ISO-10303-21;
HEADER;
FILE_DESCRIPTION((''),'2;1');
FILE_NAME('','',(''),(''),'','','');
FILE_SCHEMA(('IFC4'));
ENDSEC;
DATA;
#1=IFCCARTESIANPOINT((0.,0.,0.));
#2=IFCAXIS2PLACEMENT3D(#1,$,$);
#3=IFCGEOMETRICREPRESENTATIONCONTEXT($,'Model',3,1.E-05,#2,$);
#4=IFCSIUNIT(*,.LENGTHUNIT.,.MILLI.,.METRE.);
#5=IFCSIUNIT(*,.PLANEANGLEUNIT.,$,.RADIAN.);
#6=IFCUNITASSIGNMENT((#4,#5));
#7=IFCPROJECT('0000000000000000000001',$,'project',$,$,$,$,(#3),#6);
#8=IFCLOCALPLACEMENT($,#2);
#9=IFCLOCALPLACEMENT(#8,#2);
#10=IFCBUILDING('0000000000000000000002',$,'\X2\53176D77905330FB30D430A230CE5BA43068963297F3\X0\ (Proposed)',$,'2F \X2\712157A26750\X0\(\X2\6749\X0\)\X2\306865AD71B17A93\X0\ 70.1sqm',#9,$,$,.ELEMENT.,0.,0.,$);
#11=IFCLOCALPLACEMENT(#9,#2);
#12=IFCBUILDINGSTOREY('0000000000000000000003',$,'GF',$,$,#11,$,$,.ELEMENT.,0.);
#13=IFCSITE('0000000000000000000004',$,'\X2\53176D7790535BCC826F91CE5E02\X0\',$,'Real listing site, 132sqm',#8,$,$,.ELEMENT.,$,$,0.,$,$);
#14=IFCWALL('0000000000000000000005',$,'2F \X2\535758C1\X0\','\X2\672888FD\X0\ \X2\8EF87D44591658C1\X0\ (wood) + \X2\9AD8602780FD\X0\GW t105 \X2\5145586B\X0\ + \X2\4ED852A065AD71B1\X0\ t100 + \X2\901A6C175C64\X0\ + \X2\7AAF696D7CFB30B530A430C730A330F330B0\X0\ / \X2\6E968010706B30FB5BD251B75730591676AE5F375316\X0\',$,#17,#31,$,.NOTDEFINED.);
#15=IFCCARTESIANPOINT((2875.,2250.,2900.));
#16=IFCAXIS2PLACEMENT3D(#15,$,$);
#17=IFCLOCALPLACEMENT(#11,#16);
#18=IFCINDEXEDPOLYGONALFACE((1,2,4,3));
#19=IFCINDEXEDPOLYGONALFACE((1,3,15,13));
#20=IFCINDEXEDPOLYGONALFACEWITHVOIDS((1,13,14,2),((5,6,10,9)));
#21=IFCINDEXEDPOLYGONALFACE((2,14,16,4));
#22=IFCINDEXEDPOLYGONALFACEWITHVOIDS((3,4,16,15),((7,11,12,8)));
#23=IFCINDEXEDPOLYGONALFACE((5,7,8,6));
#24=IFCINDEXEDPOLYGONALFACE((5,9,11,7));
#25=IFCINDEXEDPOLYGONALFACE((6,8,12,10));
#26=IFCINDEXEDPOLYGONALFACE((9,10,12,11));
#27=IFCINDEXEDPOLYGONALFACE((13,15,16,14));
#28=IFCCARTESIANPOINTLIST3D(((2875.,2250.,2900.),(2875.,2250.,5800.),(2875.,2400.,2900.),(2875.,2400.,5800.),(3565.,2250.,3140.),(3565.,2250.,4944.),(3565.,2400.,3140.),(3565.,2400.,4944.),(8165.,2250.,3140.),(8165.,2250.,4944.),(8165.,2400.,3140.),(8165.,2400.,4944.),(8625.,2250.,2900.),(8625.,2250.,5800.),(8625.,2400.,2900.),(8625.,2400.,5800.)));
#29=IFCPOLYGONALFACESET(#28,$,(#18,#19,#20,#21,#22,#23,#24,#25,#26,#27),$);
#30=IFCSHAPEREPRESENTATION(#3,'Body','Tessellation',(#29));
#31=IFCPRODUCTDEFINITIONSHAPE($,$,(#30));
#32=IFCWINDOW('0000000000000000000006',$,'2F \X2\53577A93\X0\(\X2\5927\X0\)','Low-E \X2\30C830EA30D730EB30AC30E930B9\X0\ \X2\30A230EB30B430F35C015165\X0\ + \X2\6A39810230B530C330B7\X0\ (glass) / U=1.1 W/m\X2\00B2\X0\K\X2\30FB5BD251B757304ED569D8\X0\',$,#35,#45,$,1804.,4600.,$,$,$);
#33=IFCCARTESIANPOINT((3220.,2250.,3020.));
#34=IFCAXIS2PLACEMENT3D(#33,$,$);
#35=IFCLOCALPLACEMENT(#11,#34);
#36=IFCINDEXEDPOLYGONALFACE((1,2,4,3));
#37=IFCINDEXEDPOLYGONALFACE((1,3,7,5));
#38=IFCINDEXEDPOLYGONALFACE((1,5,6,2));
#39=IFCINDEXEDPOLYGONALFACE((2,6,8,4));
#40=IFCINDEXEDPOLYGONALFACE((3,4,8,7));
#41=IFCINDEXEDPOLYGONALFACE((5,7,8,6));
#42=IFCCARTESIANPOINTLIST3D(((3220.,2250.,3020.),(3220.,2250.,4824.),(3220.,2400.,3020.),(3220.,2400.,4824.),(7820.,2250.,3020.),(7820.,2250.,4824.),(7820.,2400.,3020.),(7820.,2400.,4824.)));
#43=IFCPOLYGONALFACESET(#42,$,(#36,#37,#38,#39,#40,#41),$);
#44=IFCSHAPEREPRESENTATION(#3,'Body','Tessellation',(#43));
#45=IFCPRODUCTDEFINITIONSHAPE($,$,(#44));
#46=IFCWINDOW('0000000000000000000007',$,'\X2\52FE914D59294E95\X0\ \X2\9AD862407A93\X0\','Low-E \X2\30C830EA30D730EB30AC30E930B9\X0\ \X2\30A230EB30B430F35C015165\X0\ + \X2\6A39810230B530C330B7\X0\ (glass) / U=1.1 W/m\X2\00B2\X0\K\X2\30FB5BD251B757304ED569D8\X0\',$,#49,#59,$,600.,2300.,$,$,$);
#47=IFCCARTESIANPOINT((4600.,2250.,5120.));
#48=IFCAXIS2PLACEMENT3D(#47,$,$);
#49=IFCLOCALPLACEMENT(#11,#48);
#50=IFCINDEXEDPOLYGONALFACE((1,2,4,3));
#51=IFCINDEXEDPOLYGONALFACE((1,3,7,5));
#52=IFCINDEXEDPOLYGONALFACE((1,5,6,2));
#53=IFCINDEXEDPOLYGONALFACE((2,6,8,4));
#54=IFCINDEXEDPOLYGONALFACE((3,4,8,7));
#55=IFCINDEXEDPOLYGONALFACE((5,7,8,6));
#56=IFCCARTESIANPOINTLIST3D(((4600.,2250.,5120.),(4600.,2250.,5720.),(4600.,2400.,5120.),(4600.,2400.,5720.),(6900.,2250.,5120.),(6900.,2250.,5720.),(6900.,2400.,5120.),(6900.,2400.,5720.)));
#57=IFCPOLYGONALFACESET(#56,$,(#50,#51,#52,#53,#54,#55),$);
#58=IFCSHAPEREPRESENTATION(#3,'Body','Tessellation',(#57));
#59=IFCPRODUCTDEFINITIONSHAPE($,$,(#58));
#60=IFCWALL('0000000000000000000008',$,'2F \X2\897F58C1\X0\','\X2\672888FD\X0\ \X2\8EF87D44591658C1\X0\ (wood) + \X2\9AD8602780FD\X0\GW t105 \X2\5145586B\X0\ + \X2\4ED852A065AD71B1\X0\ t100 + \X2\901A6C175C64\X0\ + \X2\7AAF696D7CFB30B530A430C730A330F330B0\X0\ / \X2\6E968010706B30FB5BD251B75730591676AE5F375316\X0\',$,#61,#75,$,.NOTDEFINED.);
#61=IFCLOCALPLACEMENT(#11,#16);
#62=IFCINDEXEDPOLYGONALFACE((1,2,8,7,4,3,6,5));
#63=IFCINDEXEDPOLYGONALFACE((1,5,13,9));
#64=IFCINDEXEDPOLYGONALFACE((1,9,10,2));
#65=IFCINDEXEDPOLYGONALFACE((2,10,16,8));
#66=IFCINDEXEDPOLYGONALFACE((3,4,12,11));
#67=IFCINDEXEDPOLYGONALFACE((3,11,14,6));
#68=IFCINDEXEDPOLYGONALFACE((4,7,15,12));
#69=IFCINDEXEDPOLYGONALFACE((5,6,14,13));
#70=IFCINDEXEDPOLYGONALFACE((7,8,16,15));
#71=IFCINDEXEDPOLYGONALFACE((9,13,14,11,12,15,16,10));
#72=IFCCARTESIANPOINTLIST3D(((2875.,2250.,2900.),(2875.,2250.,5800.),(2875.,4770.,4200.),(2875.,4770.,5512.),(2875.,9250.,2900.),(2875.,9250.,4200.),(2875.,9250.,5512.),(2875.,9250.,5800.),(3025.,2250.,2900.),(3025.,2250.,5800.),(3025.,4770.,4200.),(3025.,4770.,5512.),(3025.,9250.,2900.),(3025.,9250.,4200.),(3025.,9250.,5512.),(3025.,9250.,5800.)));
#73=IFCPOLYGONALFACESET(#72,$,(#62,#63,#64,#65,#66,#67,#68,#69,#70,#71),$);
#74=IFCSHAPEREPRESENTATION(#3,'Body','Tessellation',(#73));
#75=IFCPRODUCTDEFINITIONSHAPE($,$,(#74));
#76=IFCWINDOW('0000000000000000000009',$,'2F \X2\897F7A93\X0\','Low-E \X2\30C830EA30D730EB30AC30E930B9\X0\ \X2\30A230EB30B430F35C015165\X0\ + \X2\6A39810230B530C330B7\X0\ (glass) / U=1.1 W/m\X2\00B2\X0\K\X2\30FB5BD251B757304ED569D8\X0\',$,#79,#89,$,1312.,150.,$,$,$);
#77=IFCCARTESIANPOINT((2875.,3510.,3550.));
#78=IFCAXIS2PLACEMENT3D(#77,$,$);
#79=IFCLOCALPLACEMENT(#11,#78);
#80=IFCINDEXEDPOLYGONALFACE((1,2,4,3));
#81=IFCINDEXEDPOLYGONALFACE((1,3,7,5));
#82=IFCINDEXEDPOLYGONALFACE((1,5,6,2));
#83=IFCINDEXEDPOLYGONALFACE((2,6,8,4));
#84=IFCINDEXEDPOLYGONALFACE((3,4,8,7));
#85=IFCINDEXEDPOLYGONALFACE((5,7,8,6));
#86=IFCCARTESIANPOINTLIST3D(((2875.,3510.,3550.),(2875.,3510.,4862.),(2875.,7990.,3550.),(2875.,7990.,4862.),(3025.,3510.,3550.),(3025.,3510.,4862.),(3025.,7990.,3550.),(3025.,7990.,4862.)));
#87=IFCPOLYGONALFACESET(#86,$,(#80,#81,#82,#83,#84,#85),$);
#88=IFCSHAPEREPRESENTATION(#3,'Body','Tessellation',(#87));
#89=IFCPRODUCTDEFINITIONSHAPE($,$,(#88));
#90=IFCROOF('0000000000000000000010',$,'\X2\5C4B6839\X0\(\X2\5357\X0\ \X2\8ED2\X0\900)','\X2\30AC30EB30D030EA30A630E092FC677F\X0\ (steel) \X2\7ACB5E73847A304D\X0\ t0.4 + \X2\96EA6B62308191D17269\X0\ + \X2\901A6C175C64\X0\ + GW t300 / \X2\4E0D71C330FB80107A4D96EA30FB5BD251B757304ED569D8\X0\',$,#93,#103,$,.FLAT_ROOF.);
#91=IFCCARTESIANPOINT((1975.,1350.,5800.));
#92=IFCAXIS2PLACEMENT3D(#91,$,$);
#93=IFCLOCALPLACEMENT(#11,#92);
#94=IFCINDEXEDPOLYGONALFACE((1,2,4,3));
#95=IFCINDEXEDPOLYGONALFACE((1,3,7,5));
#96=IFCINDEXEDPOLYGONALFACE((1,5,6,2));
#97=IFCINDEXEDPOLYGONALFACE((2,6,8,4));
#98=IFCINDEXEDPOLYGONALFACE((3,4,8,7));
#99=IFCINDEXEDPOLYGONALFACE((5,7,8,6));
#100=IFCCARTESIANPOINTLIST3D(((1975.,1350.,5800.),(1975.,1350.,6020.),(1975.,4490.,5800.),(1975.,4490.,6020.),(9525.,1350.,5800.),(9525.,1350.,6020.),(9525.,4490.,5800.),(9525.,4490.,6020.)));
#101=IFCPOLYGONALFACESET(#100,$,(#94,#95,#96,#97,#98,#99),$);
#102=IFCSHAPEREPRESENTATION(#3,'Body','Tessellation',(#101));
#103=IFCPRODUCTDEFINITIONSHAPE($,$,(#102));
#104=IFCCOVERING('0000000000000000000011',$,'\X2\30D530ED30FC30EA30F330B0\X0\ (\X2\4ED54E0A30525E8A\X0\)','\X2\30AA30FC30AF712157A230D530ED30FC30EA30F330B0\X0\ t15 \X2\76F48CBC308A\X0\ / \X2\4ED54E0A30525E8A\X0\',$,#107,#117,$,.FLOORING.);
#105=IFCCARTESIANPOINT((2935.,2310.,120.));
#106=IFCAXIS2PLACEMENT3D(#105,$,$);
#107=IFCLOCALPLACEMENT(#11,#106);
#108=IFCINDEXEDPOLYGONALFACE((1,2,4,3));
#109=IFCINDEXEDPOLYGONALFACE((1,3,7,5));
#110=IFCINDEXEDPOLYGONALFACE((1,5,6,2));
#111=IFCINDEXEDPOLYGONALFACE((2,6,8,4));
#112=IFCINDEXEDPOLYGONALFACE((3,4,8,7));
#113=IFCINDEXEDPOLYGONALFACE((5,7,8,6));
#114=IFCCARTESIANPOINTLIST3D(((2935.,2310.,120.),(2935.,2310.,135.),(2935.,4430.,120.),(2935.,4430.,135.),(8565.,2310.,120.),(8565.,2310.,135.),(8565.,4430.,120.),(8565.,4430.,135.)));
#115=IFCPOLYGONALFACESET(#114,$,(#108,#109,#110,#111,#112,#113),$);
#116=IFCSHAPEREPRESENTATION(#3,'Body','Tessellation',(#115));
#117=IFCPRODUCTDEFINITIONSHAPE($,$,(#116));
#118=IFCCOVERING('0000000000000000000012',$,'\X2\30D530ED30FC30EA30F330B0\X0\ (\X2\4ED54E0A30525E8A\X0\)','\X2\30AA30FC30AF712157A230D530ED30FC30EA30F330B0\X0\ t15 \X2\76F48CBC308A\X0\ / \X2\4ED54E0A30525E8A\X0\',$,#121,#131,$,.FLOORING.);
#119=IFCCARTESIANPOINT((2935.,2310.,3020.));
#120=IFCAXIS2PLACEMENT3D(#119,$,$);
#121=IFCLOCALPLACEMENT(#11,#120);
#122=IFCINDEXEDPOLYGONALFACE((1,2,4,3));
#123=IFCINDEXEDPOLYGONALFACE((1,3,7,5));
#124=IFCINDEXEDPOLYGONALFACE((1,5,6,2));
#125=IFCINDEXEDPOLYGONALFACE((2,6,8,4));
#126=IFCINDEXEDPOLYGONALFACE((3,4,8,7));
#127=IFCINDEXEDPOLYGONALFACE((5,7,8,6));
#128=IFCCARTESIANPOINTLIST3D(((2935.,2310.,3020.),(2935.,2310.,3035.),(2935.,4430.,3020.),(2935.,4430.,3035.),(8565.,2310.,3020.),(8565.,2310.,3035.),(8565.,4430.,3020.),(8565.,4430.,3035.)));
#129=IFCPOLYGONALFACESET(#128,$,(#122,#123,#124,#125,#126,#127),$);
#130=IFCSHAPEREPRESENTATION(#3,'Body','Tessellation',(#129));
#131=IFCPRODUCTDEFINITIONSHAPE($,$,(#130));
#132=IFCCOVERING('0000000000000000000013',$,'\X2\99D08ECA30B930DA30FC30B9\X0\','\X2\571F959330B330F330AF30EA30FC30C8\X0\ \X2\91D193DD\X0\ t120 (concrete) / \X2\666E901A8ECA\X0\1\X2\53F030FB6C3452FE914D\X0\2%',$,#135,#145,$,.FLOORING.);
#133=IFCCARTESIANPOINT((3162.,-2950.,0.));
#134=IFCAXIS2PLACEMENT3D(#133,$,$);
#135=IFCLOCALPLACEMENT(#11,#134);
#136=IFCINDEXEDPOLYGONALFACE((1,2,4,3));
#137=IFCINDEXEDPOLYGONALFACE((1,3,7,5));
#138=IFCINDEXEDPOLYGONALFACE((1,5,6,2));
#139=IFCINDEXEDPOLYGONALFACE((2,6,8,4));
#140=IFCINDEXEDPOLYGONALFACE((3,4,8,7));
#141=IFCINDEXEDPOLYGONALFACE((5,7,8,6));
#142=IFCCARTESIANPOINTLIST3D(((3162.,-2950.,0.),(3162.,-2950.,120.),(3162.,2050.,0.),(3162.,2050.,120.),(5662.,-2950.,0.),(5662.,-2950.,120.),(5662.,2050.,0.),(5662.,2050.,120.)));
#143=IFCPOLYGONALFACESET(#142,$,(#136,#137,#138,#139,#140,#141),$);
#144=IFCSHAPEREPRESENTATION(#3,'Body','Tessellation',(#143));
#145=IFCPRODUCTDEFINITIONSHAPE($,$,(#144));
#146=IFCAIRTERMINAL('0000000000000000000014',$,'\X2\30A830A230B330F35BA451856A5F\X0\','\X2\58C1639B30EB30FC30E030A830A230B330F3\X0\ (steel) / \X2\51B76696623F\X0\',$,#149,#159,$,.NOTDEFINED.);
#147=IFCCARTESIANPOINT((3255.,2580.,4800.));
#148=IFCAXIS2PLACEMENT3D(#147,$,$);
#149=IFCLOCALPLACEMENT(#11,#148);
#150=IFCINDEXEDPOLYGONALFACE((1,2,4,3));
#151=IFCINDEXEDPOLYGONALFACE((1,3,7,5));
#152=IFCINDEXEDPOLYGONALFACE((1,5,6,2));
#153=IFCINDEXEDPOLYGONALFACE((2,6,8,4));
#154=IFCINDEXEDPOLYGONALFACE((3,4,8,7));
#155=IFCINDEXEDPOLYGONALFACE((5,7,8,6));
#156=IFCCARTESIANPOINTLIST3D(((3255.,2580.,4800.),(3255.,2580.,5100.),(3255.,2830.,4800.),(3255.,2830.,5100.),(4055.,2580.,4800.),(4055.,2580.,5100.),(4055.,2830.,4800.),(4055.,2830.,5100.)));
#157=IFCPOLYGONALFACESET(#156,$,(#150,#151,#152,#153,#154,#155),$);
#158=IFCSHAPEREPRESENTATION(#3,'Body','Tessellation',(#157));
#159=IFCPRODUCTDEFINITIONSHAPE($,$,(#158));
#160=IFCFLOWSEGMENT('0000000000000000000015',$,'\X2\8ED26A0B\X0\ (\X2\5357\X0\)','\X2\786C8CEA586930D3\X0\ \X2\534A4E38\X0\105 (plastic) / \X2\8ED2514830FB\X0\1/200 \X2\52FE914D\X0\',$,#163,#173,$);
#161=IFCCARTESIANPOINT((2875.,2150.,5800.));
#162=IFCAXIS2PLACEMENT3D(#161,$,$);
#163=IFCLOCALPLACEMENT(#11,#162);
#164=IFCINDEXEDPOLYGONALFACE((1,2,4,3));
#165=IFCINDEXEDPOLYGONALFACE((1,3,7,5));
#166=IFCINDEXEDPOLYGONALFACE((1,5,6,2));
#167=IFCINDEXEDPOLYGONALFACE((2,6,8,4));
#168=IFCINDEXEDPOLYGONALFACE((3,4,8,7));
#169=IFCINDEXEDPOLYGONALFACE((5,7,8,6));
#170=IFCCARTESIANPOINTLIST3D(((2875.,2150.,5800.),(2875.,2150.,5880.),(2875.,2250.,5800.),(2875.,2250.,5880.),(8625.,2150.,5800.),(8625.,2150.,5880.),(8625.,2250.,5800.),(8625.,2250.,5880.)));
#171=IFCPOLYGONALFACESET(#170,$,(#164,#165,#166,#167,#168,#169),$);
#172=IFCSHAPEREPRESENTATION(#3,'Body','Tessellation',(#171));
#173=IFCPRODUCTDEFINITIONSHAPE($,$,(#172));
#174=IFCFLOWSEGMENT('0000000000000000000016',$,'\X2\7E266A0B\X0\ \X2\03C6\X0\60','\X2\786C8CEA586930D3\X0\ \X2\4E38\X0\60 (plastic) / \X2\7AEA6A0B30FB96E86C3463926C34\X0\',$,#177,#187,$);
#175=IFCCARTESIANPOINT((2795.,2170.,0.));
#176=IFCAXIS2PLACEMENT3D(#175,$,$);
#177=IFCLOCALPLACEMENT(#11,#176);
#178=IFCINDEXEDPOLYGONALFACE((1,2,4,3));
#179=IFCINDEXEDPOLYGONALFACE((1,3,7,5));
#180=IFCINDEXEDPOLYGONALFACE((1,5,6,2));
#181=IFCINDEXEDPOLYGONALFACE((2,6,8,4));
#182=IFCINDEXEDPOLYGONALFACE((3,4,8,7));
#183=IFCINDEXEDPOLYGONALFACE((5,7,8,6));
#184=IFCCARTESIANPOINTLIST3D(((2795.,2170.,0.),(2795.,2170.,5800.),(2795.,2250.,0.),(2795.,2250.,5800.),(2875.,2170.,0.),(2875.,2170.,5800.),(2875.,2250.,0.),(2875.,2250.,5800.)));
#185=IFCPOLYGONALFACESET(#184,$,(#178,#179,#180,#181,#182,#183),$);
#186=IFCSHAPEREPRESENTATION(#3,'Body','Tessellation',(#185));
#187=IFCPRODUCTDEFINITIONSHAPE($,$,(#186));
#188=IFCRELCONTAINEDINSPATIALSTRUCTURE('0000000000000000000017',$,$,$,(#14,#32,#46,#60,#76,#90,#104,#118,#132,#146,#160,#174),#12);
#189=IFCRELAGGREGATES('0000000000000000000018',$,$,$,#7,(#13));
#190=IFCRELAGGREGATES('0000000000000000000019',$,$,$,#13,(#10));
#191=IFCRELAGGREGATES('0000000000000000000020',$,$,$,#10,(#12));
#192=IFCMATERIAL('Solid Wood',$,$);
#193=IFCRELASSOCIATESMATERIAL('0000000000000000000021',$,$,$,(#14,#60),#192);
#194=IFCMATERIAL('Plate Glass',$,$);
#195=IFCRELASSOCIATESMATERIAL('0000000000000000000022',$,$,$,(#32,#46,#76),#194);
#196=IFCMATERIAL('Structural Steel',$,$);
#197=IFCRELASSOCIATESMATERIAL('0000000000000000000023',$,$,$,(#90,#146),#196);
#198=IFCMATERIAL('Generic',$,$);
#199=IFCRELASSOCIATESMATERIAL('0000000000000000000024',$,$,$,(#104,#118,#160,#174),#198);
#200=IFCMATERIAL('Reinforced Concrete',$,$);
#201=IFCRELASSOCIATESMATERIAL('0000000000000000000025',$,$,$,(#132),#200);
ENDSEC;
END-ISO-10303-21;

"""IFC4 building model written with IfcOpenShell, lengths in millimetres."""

from ifc_helpers import new_model, si_unit, frame, frame_2d, origin, place, context, project, spatial, rectangle, extrude, material, element, fill, save


model = new_model("IFC4")

# Units and contexts
model_context = context("Model", 3, precision=1e-05, world=origin())
ifc_project = project(units=[si_unit("LENGTHUNIT", "METRE", prefix="MILLI"), si_unit("PLANEANGLEUNIT", "RADIAN")], contexts=[model_context])

# Site, building, storey
site_placement = place(None, origin())
site = spatial("IfcSite", under=ifc_project, at=site_placement, Name="北海道富良野市", ObjectType="Real listing site, 132sqm", CompositionType="ELEMENT", RefElevation=0.0)
building_placement = place(site_placement, origin())
building = spatial("IfcBuilding", under=site, at=building_placement, Name="北海道・ピアノ室と防音 (Proposed)", ObjectType="2F 無垢材(杉)と断熱窓 70.1sqm", CompositionType="ELEMENT", ElevationOfRefHeight=0.0, ElevationOfTerrain=0.0)
storey_placement = place(building_placement, origin())
storey = spatial("IfcBuildingStorey", under=building, at=storey_placement, Name="GF", CompositionType="ELEMENT", Elevation=0.0)

# Shared definitions
ifc_material_1 = material(Name="Solid Wood")

# Shared definitions
ifc_material_2 = material(Name="Reinforced Concrete")

# Shared definitions
ifc_material_3 = material(Name="Plate Glass")

# Wall, openings, windows
wall_1_placement = place(storey_placement, frame((2875.0, 2250.0, 2900.0)))
wall_1 = element("IfcWall", 1, at=wall_1_placement, inside=storey, material=ifc_material_1, Name="2F 南壁", Description="木製 軸組外壁 (wood) + 高性能GW t105 充填 + 付加断熱 t100 + 通気層 + 窯業系サイディング / 準耐火・寒冷地外皮強化", PredefinedType="NOTDEFINED", context=model_context, shape_type="SweptSolid", body=[
    extrude(rectangle(XDim=5750.0, YDim=150.0, at=frame_2d((2875.0, 75.0))), frame((2875.0, 2250.0, 2900.0)), (0.0, 0.0, 1.0), 2900.0),
])
opening_1_placement = place(storey_placement, frame((3220.0, 2250.0, 3020.0)))
opening_1 = element("IfcOpeningElement", 2, at=opening_1_placement, cuts=wall_1, PredefinedType="NOTDEFINED", context=model_context, shape_type="SweptSolid", body=[
    extrude(rectangle(XDim=4600.0, YDim=150.0, at=frame_2d((2300.0, 75.0))), frame((3220.0, 2250.0, 3020.0)), (0.0, 0.0, 1.0), 1804.0),
])
opening_2_placement = place(storey_placement, frame((4600.0, 2250.0, 5120.0)))
opening_2 = element("IfcOpeningElement", 3, at=opening_2_placement, cuts=wall_1, PredefinedType="NOTDEFINED", context=model_context, shape_type="SweptSolid", body=[
    extrude(rectangle(XDim=2300.0, YDim=150.0, at=frame_2d((1150.0, 75.0))), frame((4600.0, 2250.0, 5120.0)), (0.0, 0.0, 1.0), 600.0),
])
window_1_placement = place(storey_placement, frame((3220.0, 2250.0, 3020.0)))
window_1 = element("IfcWindow", 4, at=window_1_placement, inside=storey, material=ifc_material_3, Name="2F 南窓(大)", Description="Low-E トリプルガラス アルゴン封入 + 樹脂サッシ (glass) / U=1.1 W/m²K・寒冷地仕様", OverallHeight=1804.0, OverallWidth=4600.0, context=model_context, shape_type="SweptSolid", body=[
    extrude(rectangle(XDim=4600.0, YDim=150.0, at=frame_2d((2300.0, 75.0))), frame((3220.0, 2250.0, 3020.0)), (0.0, 0.0, 1.0), 1804.0),
])
fill(opening_1, window_1)
window_2_placement = place(storey_placement, frame((4600.0, 2250.0, 5120.0)))
window_2 = element("IfcWindow", 5, at=window_2_placement, inside=storey, material=ifc_material_3, Name="勾配天井 高所窓", Description="Low-E トリプルガラス アルゴン封入 + 樹脂サッシ (glass) / U=1.1 W/m²K・寒冷地仕様", OverallHeight=600.0, OverallWidth=2300.0, context=model_context, shape_type="SweptSolid", body=[
    extrude(rectangle(XDim=2300.0, YDim=150.0, at=frame_2d((1150.0, 75.0))), frame((4600.0, 2250.0, 5120.0)), (0.0, 0.0, 1.0), 600.0),
])
fill(opening_2, window_2)

# Wall, opening, window
wall_2_placement = place(storey_placement, frame((2875.0, 2250.0, 2900.0)))
wall_2 = element("IfcWall", 6, at=wall_2_placement, inside=storey, material=ifc_material_1, Name="2F 西壁", Description="木製 軸組外壁 (wood) + 高性能GW t105 充填 + 付加断熱 t100 + 通気層 + 窯業系サイディング / 準耐火・寒冷地外皮強化", PredefinedType="NOTDEFINED", context=model_context, shape_type="SweptSolid", body=[
    extrude(rectangle(XDim=150.0, YDim=7000.0, at=frame_2d((75.0, 3500.0))), frame((2875.0, 2250.0, 2900.0)), (0.0, 0.0, 1.0), 2900.0),
])
opening_3_placement = place(storey_placement, frame((2875.0, 3510.0, 3550.0)))
opening_3 = element("IfcOpeningElement", 7, at=opening_3_placement, cuts=wall_2, PredefinedType="NOTDEFINED", context=model_context, shape_type="SweptSolid", body=[
    extrude(rectangle(XDim=150.0, YDim=4480.0, at=frame_2d((75.0, 2240.0))), frame((2875.0, 3510.0, 3550.0)), (0.0, 0.0, 1.0), 1312.0),
])
window_3_placement = place(storey_placement, frame((2875.0, 3510.0, 3550.0)))
window_3 = element("IfcWindow", 8, at=window_3_placement, inside=storey, material=ifc_material_3, Name="2F 西窓", Description="Low-E トリプルガラス アルゴン封入 + 樹脂サッシ (glass) / U=1.1 W/m²K・寒冷地仕様", OverallHeight=1312.0, OverallWidth=150.0, context=model_context, shape_type="SweptSolid", body=[
    extrude(rectangle(XDim=150.0, YDim=4480.0, at=frame_2d((75.0, 2240.0))), frame((2875.0, 3510.0, 3550.0)), (0.0, 0.0, 1.0), 1312.0),
])
fill(opening_3, window_3)

# Roof
ifc_material_4 = material(Name="Structural Steel")
for number, where, name in (
    (9, (1975.0, 1350.0, 5800.0), "屋根(南 軒900)"),
):
    element("IfcRoof", number, at=place(storey_placement, frame(where)), inside=storey, material=ifc_material_4, Name=name, Description="ガルバリウム鋼板 (steel) 立平葺き t0.4 + 雪止め金物 + 通気層 + GW t300 / 不燃・耐積雪・寒冷地仕様", PredefinedType="FLAT_ROOF", context=model_context, shape_type="SweptSolid", body=[
        extrude(rectangle(XDim=7550.0, YDim=3140.0, at=frame_2d((3775.0, 1570.0))), frame((1975.0, 1350.0, 5800.0)), (0.0, 0.0, 1.0), 220.0),
    ])

# Coverings
ifc_material_5 = material(Name="Generic")
covering_1_placement = place(storey_placement, frame((2935.0, 2310.0, 120.0)))
element("IfcCovering", 10, at=covering_1_placement, inside=storey, material=ifc_material_5, Name="フローリング (仕上げ床)", Description="オーク無垢フローリング t15 直貼り / 仕上げ床", PredefinedType="FLOORING", context=model_context, shape_type="SweptSolid", body=[
    extrude(rectangle(XDim=5630.0, YDim=2120.0, at=frame_2d((2815.0, 1060.0))), frame((2935.0, 2310.0, 120.0)), (0.0, 0.0, 1.0), 15.0),
])
covering_2_placement = place(storey_placement, frame((2935.0, 2310.0, 3020.0)))
element("IfcCovering", 11, at=covering_2_placement, inside=storey, material=ifc_material_5, Name="フローリング (仕上げ床)", Description="オーク無垢フローリング t15 直貼り / 仕上げ床", PredefinedType="FLOORING", context=model_context, shape_type="SweptSolid", body=[
    extrude(rectangle(XDim=5630.0, YDim=2120.0, at=frame_2d((2815.0, 1060.0))), frame((2935.0, 2310.0, 3020.0)), (0.0, 0.0, 1.0), 15.0),
])
covering_3_placement = place(storey_placement, frame((3162.0, -2950.0, 0.0)))
element("IfcCovering", 12, at=covering_3_placement, inside=storey, material=ifc_material_2, Name="駐車スペース", Description="土間コンクリート 金鏝 t120 (concrete) / 普通車1台・水勾配2%", PredefinedType="FLOORING", context=model_context, shape_type="SweptSolid", body=[
    extrude(rectangle(XDim=2500.0, YDim=5000.0, at=frame_2d((1250.0, 2500.0))), frame((3162.0, -2950.0, 0.0)), (0.0, 0.0, 1.0), 120.0),
])

# Air terminal
air_terminal_placement = place(storey_placement, frame((3255.0, 2580.0, 4800.0)))
element("IfcAirTerminal", 13, at=air_terminal_placement, inside=storey, material=ifc_material_4, Name="エアコン室内機", Description="壁掛ルームエアコン (steel) / 冷暖房", PredefinedType="NOTDEFINED", context=model_context, shape_type="SweptSolid", body=[
    extrude(rectangle(XDim=800.0, YDim=250.0, at=frame_2d((400.0, 125.0))), frame((3255.0, 2580.0, 4800.0)), (0.0, 0.0, 1.0), 300.0),
])

# Flow segments
flow_segment_1_placement = place(storey_placement, frame((2875.0, 2150.0, 5800.0)))
element("IfcFlowSegment", 14, at=flow_segment_1_placement, inside=storey, material=ifc_material_5, Name="軒樋 (南)", Description="硬質塩ビ 半丸105 (plastic) / 軒先・1/200 勾配", context=model_context, shape_type="SweptSolid", body=[
    extrude(rectangle(XDim=5750.0, YDim=100.0, at=frame_2d((2875.0, 50.0))), frame((2875.0, 2150.0, 5800.0)), (0.0, 0.0, 1.0), 80.0),
])
flow_segment_2_placement = place(storey_placement, frame((2795.0, 2170.0, 0.0)))
element("IfcFlowSegment", 15, at=flow_segment_2_placement, inside=storey, material=ifc_material_5, Name="縦樋 φ60", Description="硬質塩ビ 丸60 (plastic) / 竪樋・雨水排水", context=model_context, shape_type="SweptSolid", body=[
    extrude(rectangle(XDim=80.0, YDim=80.0, at=frame_2d((40.0, 40.0))), frame((2795.0, 2170.0, 0.0)), (0.0, 0.0, 1.0), 5800.0),
])

save(model, "model.ifc")
